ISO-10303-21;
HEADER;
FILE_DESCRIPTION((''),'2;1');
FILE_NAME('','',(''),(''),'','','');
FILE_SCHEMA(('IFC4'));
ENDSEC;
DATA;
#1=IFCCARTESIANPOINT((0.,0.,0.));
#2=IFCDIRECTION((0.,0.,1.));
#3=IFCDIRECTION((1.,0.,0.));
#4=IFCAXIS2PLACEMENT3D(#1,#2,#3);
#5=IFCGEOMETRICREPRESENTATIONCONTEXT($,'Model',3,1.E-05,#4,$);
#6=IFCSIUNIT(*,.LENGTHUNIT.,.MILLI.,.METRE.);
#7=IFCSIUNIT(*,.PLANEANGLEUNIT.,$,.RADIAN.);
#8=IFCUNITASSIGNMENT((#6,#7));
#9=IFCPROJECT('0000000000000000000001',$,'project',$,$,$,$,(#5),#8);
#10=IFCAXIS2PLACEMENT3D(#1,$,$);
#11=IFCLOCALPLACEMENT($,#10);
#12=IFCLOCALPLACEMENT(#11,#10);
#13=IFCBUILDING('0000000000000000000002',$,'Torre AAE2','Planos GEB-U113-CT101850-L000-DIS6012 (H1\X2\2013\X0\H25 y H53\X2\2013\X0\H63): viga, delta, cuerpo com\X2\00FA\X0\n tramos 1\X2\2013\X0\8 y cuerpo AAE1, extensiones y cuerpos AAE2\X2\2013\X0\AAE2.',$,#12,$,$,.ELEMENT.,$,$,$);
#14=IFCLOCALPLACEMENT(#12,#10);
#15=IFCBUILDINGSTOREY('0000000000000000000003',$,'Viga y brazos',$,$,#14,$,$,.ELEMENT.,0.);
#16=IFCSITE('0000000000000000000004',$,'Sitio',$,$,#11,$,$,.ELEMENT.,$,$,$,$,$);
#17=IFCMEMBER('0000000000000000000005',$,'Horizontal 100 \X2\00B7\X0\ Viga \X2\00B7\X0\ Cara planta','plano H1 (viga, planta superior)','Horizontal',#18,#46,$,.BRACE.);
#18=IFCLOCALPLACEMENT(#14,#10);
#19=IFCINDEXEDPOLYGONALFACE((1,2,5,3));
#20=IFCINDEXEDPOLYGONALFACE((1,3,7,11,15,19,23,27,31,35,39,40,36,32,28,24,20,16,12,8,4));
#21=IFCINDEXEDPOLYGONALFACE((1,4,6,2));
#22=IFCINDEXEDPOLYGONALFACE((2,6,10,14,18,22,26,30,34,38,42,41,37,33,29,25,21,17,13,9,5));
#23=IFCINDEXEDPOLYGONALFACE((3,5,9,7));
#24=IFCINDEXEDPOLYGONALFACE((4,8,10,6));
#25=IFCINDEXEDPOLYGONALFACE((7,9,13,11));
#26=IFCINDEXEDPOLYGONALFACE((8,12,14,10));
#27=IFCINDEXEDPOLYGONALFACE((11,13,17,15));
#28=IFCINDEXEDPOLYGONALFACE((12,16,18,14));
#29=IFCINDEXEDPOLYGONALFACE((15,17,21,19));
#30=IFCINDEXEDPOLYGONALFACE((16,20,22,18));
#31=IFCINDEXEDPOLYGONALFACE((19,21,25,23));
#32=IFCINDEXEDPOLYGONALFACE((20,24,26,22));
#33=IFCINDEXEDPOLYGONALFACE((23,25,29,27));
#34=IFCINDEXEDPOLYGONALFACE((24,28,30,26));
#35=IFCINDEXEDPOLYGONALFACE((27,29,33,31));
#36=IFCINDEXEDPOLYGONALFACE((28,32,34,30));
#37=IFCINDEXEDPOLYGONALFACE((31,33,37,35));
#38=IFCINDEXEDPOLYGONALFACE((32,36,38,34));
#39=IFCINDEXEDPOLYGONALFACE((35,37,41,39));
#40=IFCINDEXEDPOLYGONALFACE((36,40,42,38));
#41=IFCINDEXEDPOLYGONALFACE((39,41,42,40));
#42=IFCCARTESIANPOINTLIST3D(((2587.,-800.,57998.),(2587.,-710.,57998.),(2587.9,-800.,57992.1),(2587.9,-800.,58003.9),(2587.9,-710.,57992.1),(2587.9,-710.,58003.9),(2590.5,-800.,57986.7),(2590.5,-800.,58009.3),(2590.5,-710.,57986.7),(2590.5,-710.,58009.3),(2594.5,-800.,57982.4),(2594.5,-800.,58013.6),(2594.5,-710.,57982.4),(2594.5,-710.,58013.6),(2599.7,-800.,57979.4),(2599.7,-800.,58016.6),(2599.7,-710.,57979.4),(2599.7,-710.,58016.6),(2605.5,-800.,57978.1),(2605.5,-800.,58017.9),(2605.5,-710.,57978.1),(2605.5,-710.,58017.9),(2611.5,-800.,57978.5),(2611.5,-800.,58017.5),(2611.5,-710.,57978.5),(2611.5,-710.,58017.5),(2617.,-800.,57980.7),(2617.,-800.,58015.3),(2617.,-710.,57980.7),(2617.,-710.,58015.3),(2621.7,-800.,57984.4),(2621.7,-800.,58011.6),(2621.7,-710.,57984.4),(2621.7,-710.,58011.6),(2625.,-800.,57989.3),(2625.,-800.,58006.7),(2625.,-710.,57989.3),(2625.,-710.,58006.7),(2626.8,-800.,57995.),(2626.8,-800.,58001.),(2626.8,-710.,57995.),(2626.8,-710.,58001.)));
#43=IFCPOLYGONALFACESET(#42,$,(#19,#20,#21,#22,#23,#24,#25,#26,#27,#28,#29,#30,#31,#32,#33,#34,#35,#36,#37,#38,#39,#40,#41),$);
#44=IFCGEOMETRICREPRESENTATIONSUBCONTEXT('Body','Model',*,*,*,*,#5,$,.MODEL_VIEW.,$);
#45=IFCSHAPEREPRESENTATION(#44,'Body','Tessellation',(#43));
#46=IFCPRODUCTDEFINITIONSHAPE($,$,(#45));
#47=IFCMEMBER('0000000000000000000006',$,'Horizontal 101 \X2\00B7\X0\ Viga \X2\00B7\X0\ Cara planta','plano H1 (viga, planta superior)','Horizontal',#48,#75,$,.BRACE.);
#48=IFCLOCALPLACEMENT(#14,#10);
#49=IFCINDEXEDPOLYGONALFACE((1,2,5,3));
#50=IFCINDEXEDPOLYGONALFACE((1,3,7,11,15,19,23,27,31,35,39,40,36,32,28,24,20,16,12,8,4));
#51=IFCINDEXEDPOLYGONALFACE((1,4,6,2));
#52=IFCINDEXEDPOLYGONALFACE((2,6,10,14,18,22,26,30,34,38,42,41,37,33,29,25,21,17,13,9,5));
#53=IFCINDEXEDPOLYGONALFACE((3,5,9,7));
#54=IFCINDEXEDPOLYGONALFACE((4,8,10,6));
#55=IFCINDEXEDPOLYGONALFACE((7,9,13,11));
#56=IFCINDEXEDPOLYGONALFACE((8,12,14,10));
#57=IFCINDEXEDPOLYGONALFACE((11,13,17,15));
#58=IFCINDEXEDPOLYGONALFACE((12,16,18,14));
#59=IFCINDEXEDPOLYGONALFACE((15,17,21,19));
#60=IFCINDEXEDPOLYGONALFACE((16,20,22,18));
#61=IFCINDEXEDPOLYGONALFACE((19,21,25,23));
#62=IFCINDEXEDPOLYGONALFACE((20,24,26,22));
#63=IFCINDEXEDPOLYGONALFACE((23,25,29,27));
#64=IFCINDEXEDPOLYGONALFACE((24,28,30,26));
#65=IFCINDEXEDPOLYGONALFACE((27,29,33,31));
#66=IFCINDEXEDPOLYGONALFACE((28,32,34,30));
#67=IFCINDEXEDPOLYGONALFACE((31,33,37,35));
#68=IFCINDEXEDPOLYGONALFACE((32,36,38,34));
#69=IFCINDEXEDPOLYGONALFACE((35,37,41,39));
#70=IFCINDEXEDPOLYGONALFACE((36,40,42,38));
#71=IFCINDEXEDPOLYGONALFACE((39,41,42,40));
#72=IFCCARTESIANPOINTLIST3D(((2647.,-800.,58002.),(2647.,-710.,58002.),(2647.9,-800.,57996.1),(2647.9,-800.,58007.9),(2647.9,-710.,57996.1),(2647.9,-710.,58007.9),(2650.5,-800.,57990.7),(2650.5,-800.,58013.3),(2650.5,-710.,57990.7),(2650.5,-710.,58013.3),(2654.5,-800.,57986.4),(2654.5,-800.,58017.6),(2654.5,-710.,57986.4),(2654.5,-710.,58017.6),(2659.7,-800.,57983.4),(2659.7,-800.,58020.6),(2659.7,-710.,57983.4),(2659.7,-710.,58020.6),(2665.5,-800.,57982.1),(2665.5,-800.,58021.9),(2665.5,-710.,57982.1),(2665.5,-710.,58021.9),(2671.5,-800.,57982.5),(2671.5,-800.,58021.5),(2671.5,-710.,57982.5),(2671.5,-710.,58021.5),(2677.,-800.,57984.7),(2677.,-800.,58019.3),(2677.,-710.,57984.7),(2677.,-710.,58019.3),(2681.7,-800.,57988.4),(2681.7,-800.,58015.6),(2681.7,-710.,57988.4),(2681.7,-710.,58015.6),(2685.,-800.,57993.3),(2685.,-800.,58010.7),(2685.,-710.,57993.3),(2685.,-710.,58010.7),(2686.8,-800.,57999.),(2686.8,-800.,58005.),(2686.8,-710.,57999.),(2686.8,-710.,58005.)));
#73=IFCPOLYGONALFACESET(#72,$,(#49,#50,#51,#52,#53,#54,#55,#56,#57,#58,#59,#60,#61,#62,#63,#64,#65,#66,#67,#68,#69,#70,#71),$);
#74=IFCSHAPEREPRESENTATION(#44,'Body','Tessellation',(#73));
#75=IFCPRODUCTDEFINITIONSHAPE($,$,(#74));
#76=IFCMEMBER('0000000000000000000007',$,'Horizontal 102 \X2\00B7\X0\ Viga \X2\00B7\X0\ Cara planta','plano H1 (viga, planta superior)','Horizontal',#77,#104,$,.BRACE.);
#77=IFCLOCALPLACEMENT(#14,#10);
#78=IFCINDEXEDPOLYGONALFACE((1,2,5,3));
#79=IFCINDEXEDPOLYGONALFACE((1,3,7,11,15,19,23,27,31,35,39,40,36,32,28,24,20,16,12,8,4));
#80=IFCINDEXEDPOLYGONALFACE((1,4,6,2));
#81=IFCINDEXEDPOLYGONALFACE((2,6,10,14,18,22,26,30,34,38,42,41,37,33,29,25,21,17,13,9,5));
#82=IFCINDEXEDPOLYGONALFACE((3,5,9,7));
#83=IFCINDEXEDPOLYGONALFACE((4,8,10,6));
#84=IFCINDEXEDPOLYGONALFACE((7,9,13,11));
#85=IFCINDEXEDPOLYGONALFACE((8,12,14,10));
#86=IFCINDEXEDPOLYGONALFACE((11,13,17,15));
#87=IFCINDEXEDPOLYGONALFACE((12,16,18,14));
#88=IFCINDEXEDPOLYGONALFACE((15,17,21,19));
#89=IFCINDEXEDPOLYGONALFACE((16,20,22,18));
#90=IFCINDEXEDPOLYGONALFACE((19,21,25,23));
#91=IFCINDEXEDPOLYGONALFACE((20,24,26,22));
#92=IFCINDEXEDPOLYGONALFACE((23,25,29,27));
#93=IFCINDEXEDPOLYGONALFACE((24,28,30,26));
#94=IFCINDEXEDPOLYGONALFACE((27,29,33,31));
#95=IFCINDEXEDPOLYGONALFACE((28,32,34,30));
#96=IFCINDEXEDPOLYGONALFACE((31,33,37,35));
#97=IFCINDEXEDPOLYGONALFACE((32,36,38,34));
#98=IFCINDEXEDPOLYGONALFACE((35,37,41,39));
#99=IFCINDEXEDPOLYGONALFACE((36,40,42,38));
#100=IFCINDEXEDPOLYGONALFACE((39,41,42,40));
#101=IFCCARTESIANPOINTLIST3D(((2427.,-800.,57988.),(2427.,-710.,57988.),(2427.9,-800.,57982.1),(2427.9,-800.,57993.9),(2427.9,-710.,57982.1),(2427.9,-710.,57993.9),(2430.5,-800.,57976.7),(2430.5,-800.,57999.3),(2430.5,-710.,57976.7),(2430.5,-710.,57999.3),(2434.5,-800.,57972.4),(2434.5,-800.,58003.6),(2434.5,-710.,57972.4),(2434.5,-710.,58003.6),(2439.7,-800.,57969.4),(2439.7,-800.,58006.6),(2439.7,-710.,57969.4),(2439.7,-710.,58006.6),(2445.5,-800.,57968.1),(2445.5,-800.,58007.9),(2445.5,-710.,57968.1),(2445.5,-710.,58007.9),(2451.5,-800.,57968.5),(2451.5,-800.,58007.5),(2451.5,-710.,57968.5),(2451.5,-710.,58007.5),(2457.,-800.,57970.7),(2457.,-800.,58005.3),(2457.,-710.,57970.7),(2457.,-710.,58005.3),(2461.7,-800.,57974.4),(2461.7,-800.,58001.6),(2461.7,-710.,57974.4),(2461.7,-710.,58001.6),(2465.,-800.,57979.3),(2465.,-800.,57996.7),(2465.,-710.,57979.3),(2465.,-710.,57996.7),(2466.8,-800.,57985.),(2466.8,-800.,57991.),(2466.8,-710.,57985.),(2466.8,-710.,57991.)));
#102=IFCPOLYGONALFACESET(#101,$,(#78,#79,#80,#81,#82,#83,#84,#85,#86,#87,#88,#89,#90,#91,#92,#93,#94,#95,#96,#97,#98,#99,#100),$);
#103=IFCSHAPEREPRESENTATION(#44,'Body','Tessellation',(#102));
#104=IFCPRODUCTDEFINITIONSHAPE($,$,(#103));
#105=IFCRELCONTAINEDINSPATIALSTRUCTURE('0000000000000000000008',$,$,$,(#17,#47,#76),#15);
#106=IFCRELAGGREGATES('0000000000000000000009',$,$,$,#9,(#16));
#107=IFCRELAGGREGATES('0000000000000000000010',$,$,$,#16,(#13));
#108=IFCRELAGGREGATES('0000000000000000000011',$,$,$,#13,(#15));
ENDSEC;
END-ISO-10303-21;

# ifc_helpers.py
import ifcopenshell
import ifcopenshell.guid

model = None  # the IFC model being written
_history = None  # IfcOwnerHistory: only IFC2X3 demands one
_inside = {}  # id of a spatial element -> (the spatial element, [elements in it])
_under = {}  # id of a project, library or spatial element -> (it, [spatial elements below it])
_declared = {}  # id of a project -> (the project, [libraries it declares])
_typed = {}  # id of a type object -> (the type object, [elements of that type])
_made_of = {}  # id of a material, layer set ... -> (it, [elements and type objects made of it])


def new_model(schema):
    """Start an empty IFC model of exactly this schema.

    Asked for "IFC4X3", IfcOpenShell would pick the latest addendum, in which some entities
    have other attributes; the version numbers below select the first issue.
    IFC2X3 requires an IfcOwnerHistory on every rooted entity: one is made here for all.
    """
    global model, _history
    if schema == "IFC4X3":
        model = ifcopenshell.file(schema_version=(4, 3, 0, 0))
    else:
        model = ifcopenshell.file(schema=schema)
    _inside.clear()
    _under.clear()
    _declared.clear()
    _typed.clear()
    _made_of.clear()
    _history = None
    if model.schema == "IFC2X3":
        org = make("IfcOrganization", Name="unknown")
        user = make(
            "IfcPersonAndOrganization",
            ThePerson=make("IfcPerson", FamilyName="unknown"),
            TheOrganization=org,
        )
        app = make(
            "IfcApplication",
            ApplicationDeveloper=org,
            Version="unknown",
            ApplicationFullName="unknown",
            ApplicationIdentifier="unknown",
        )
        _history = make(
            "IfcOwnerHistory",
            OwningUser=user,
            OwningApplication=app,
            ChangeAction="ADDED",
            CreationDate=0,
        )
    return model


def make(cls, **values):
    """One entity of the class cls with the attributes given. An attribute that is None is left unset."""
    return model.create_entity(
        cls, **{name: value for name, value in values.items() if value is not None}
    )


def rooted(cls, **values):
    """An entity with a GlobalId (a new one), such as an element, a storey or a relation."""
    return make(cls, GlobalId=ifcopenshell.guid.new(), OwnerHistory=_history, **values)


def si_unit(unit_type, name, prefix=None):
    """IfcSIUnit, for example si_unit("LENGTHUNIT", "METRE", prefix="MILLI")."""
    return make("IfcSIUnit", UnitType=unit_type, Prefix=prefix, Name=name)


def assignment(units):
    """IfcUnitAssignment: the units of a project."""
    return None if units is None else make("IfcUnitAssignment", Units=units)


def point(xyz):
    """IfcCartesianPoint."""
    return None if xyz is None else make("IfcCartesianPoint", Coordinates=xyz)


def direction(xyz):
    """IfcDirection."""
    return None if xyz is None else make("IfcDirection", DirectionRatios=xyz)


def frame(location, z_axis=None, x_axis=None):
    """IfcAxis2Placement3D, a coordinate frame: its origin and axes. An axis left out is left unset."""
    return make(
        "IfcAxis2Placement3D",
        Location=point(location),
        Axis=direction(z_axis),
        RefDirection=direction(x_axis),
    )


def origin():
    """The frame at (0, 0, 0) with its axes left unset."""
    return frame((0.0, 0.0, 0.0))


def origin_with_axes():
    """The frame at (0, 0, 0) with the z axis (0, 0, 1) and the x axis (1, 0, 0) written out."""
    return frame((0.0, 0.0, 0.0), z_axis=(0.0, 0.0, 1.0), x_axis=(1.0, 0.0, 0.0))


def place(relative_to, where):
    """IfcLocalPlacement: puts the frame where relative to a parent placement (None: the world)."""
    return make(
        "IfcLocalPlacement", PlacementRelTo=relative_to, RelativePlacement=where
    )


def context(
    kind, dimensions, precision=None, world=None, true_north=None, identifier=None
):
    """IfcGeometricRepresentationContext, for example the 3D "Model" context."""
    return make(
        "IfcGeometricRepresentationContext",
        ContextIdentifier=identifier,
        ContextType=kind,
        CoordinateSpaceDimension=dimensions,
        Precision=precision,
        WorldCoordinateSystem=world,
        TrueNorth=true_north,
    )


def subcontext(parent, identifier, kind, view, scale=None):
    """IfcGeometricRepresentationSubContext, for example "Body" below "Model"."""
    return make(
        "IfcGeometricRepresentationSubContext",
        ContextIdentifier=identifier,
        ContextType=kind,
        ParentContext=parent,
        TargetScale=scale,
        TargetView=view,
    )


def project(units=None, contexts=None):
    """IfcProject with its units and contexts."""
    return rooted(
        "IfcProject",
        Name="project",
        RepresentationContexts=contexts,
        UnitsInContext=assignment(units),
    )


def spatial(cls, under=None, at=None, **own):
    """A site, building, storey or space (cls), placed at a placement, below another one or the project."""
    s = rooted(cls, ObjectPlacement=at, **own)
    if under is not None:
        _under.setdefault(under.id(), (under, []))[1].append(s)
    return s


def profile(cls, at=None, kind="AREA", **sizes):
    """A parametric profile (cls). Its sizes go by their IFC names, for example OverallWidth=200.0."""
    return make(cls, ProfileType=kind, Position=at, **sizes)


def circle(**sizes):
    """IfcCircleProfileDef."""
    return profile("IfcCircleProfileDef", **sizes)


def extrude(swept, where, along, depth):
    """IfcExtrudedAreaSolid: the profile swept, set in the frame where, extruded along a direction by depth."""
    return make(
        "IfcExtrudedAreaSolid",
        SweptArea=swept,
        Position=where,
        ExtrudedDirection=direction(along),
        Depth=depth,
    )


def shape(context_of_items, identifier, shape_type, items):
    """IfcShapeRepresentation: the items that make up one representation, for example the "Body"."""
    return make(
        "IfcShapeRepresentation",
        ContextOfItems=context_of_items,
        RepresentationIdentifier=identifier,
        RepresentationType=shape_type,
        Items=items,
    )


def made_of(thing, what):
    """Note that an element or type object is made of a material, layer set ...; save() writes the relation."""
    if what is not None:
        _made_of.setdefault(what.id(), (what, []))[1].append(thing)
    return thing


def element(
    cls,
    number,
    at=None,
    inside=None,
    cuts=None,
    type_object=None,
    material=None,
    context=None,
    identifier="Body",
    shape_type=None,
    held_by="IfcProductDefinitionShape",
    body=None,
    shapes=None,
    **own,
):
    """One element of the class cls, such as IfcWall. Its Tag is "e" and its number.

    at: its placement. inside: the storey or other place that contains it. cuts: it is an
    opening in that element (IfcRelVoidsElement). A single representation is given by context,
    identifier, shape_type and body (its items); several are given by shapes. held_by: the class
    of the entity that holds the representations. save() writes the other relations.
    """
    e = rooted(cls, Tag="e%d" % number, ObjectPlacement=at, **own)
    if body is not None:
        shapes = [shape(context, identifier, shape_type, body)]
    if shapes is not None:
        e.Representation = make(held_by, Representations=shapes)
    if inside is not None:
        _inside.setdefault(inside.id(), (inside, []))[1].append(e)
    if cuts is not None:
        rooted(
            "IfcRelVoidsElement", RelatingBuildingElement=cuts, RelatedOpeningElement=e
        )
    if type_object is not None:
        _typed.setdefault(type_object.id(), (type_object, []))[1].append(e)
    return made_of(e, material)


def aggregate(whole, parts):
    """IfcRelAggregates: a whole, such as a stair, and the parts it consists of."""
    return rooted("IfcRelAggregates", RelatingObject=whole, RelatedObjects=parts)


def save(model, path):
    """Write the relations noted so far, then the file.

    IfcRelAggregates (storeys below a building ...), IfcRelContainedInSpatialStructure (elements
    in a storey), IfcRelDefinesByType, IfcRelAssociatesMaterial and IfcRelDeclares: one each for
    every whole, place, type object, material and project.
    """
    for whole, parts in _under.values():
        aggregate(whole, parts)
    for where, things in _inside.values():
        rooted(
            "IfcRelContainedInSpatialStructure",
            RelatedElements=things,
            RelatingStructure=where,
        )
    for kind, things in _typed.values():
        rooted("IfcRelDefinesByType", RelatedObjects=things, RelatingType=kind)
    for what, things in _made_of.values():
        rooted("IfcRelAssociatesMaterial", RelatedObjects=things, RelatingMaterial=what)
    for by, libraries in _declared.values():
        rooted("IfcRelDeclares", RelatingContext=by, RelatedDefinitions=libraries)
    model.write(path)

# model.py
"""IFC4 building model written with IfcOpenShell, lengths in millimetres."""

from ifc_helpers import new_model, si_unit, frame, origin, origin_with_axes, place, context, subcontext, project, spatial, circle, extrude, element, save


model = new_model("IFC4")

# Units and contexts
model_context = context("Model", 3, precision=1e-05, world=origin_with_axes())
body_context = subcontext(model_context, "Body", "Model", "MODEL_VIEW")
ifc_project = project(units=[si_unit("LENGTHUNIT", "METRE", prefix="MILLI"), si_unit("PLANEANGLEUNIT", "RADIAN")], contexts=[model_context])

# Site, building, storey
site_placement = place(None, origin())
site = spatial("IfcSite", under=ifc_project, at=site_placement, Name="Sitio", CompositionType="ELEMENT")
building_placement = place(site_placement, origin())
building = spatial("IfcBuilding", under=site, at=building_placement, Name="Torre AAE2", Description="Planos GEB-U113-CT101850-L000-DIS6012 (H1–H25 y H53–H63): viga, delta, cuerpo común tramos 1–8 y cuerpo AAE1, extensiones y cuerpos AAE2–AAE2.", CompositionType="ELEMENT")
storey_placement = place(building_placement, origin())
storey = spatial("IfcBuildingStorey", under=building, at=storey_placement, Name="Viga y brazos", CompositionType="ELEMENT", Elevation=0.0)

# Members
for number, where, z_axis, x_axis, name in (
    (1, (2607.0, -710.0, 57998.0), (0.0, -1.0, 0.0), (-1.0, 0.0, 0.0), "Horizontal 100 · Viga · Cara planta"),
    (2, (2667.0, -710.0, 58002.0), (0.0, -1.0, 0.0), (-1.0, 0.0, 0.0), "Horizontal 101 · Viga · Cara planta"),
    (3, (2447.0, -710.0, 57988.0), (0.0, -1.0, 0.0), (-1.0, 0.0, 0.0), "Horizontal 102 · Viga · Cara planta"),
):
    element("IfcMember", number, at=place(storey_placement, frame(where, z_axis=z_axis, x_axis=x_axis)), inside=storey, Name=name, Description="plano H1 (viga, planta superior)", ObjectType="Horizontal", PredefinedType="BRACE", context=body_context, shape_type="SweptSolid", body=[
        extrude(circle(Radius=20.0), None, (0.0, 0.0, 1.0), 90.0),
    ])

save(model, "model.ifc")
